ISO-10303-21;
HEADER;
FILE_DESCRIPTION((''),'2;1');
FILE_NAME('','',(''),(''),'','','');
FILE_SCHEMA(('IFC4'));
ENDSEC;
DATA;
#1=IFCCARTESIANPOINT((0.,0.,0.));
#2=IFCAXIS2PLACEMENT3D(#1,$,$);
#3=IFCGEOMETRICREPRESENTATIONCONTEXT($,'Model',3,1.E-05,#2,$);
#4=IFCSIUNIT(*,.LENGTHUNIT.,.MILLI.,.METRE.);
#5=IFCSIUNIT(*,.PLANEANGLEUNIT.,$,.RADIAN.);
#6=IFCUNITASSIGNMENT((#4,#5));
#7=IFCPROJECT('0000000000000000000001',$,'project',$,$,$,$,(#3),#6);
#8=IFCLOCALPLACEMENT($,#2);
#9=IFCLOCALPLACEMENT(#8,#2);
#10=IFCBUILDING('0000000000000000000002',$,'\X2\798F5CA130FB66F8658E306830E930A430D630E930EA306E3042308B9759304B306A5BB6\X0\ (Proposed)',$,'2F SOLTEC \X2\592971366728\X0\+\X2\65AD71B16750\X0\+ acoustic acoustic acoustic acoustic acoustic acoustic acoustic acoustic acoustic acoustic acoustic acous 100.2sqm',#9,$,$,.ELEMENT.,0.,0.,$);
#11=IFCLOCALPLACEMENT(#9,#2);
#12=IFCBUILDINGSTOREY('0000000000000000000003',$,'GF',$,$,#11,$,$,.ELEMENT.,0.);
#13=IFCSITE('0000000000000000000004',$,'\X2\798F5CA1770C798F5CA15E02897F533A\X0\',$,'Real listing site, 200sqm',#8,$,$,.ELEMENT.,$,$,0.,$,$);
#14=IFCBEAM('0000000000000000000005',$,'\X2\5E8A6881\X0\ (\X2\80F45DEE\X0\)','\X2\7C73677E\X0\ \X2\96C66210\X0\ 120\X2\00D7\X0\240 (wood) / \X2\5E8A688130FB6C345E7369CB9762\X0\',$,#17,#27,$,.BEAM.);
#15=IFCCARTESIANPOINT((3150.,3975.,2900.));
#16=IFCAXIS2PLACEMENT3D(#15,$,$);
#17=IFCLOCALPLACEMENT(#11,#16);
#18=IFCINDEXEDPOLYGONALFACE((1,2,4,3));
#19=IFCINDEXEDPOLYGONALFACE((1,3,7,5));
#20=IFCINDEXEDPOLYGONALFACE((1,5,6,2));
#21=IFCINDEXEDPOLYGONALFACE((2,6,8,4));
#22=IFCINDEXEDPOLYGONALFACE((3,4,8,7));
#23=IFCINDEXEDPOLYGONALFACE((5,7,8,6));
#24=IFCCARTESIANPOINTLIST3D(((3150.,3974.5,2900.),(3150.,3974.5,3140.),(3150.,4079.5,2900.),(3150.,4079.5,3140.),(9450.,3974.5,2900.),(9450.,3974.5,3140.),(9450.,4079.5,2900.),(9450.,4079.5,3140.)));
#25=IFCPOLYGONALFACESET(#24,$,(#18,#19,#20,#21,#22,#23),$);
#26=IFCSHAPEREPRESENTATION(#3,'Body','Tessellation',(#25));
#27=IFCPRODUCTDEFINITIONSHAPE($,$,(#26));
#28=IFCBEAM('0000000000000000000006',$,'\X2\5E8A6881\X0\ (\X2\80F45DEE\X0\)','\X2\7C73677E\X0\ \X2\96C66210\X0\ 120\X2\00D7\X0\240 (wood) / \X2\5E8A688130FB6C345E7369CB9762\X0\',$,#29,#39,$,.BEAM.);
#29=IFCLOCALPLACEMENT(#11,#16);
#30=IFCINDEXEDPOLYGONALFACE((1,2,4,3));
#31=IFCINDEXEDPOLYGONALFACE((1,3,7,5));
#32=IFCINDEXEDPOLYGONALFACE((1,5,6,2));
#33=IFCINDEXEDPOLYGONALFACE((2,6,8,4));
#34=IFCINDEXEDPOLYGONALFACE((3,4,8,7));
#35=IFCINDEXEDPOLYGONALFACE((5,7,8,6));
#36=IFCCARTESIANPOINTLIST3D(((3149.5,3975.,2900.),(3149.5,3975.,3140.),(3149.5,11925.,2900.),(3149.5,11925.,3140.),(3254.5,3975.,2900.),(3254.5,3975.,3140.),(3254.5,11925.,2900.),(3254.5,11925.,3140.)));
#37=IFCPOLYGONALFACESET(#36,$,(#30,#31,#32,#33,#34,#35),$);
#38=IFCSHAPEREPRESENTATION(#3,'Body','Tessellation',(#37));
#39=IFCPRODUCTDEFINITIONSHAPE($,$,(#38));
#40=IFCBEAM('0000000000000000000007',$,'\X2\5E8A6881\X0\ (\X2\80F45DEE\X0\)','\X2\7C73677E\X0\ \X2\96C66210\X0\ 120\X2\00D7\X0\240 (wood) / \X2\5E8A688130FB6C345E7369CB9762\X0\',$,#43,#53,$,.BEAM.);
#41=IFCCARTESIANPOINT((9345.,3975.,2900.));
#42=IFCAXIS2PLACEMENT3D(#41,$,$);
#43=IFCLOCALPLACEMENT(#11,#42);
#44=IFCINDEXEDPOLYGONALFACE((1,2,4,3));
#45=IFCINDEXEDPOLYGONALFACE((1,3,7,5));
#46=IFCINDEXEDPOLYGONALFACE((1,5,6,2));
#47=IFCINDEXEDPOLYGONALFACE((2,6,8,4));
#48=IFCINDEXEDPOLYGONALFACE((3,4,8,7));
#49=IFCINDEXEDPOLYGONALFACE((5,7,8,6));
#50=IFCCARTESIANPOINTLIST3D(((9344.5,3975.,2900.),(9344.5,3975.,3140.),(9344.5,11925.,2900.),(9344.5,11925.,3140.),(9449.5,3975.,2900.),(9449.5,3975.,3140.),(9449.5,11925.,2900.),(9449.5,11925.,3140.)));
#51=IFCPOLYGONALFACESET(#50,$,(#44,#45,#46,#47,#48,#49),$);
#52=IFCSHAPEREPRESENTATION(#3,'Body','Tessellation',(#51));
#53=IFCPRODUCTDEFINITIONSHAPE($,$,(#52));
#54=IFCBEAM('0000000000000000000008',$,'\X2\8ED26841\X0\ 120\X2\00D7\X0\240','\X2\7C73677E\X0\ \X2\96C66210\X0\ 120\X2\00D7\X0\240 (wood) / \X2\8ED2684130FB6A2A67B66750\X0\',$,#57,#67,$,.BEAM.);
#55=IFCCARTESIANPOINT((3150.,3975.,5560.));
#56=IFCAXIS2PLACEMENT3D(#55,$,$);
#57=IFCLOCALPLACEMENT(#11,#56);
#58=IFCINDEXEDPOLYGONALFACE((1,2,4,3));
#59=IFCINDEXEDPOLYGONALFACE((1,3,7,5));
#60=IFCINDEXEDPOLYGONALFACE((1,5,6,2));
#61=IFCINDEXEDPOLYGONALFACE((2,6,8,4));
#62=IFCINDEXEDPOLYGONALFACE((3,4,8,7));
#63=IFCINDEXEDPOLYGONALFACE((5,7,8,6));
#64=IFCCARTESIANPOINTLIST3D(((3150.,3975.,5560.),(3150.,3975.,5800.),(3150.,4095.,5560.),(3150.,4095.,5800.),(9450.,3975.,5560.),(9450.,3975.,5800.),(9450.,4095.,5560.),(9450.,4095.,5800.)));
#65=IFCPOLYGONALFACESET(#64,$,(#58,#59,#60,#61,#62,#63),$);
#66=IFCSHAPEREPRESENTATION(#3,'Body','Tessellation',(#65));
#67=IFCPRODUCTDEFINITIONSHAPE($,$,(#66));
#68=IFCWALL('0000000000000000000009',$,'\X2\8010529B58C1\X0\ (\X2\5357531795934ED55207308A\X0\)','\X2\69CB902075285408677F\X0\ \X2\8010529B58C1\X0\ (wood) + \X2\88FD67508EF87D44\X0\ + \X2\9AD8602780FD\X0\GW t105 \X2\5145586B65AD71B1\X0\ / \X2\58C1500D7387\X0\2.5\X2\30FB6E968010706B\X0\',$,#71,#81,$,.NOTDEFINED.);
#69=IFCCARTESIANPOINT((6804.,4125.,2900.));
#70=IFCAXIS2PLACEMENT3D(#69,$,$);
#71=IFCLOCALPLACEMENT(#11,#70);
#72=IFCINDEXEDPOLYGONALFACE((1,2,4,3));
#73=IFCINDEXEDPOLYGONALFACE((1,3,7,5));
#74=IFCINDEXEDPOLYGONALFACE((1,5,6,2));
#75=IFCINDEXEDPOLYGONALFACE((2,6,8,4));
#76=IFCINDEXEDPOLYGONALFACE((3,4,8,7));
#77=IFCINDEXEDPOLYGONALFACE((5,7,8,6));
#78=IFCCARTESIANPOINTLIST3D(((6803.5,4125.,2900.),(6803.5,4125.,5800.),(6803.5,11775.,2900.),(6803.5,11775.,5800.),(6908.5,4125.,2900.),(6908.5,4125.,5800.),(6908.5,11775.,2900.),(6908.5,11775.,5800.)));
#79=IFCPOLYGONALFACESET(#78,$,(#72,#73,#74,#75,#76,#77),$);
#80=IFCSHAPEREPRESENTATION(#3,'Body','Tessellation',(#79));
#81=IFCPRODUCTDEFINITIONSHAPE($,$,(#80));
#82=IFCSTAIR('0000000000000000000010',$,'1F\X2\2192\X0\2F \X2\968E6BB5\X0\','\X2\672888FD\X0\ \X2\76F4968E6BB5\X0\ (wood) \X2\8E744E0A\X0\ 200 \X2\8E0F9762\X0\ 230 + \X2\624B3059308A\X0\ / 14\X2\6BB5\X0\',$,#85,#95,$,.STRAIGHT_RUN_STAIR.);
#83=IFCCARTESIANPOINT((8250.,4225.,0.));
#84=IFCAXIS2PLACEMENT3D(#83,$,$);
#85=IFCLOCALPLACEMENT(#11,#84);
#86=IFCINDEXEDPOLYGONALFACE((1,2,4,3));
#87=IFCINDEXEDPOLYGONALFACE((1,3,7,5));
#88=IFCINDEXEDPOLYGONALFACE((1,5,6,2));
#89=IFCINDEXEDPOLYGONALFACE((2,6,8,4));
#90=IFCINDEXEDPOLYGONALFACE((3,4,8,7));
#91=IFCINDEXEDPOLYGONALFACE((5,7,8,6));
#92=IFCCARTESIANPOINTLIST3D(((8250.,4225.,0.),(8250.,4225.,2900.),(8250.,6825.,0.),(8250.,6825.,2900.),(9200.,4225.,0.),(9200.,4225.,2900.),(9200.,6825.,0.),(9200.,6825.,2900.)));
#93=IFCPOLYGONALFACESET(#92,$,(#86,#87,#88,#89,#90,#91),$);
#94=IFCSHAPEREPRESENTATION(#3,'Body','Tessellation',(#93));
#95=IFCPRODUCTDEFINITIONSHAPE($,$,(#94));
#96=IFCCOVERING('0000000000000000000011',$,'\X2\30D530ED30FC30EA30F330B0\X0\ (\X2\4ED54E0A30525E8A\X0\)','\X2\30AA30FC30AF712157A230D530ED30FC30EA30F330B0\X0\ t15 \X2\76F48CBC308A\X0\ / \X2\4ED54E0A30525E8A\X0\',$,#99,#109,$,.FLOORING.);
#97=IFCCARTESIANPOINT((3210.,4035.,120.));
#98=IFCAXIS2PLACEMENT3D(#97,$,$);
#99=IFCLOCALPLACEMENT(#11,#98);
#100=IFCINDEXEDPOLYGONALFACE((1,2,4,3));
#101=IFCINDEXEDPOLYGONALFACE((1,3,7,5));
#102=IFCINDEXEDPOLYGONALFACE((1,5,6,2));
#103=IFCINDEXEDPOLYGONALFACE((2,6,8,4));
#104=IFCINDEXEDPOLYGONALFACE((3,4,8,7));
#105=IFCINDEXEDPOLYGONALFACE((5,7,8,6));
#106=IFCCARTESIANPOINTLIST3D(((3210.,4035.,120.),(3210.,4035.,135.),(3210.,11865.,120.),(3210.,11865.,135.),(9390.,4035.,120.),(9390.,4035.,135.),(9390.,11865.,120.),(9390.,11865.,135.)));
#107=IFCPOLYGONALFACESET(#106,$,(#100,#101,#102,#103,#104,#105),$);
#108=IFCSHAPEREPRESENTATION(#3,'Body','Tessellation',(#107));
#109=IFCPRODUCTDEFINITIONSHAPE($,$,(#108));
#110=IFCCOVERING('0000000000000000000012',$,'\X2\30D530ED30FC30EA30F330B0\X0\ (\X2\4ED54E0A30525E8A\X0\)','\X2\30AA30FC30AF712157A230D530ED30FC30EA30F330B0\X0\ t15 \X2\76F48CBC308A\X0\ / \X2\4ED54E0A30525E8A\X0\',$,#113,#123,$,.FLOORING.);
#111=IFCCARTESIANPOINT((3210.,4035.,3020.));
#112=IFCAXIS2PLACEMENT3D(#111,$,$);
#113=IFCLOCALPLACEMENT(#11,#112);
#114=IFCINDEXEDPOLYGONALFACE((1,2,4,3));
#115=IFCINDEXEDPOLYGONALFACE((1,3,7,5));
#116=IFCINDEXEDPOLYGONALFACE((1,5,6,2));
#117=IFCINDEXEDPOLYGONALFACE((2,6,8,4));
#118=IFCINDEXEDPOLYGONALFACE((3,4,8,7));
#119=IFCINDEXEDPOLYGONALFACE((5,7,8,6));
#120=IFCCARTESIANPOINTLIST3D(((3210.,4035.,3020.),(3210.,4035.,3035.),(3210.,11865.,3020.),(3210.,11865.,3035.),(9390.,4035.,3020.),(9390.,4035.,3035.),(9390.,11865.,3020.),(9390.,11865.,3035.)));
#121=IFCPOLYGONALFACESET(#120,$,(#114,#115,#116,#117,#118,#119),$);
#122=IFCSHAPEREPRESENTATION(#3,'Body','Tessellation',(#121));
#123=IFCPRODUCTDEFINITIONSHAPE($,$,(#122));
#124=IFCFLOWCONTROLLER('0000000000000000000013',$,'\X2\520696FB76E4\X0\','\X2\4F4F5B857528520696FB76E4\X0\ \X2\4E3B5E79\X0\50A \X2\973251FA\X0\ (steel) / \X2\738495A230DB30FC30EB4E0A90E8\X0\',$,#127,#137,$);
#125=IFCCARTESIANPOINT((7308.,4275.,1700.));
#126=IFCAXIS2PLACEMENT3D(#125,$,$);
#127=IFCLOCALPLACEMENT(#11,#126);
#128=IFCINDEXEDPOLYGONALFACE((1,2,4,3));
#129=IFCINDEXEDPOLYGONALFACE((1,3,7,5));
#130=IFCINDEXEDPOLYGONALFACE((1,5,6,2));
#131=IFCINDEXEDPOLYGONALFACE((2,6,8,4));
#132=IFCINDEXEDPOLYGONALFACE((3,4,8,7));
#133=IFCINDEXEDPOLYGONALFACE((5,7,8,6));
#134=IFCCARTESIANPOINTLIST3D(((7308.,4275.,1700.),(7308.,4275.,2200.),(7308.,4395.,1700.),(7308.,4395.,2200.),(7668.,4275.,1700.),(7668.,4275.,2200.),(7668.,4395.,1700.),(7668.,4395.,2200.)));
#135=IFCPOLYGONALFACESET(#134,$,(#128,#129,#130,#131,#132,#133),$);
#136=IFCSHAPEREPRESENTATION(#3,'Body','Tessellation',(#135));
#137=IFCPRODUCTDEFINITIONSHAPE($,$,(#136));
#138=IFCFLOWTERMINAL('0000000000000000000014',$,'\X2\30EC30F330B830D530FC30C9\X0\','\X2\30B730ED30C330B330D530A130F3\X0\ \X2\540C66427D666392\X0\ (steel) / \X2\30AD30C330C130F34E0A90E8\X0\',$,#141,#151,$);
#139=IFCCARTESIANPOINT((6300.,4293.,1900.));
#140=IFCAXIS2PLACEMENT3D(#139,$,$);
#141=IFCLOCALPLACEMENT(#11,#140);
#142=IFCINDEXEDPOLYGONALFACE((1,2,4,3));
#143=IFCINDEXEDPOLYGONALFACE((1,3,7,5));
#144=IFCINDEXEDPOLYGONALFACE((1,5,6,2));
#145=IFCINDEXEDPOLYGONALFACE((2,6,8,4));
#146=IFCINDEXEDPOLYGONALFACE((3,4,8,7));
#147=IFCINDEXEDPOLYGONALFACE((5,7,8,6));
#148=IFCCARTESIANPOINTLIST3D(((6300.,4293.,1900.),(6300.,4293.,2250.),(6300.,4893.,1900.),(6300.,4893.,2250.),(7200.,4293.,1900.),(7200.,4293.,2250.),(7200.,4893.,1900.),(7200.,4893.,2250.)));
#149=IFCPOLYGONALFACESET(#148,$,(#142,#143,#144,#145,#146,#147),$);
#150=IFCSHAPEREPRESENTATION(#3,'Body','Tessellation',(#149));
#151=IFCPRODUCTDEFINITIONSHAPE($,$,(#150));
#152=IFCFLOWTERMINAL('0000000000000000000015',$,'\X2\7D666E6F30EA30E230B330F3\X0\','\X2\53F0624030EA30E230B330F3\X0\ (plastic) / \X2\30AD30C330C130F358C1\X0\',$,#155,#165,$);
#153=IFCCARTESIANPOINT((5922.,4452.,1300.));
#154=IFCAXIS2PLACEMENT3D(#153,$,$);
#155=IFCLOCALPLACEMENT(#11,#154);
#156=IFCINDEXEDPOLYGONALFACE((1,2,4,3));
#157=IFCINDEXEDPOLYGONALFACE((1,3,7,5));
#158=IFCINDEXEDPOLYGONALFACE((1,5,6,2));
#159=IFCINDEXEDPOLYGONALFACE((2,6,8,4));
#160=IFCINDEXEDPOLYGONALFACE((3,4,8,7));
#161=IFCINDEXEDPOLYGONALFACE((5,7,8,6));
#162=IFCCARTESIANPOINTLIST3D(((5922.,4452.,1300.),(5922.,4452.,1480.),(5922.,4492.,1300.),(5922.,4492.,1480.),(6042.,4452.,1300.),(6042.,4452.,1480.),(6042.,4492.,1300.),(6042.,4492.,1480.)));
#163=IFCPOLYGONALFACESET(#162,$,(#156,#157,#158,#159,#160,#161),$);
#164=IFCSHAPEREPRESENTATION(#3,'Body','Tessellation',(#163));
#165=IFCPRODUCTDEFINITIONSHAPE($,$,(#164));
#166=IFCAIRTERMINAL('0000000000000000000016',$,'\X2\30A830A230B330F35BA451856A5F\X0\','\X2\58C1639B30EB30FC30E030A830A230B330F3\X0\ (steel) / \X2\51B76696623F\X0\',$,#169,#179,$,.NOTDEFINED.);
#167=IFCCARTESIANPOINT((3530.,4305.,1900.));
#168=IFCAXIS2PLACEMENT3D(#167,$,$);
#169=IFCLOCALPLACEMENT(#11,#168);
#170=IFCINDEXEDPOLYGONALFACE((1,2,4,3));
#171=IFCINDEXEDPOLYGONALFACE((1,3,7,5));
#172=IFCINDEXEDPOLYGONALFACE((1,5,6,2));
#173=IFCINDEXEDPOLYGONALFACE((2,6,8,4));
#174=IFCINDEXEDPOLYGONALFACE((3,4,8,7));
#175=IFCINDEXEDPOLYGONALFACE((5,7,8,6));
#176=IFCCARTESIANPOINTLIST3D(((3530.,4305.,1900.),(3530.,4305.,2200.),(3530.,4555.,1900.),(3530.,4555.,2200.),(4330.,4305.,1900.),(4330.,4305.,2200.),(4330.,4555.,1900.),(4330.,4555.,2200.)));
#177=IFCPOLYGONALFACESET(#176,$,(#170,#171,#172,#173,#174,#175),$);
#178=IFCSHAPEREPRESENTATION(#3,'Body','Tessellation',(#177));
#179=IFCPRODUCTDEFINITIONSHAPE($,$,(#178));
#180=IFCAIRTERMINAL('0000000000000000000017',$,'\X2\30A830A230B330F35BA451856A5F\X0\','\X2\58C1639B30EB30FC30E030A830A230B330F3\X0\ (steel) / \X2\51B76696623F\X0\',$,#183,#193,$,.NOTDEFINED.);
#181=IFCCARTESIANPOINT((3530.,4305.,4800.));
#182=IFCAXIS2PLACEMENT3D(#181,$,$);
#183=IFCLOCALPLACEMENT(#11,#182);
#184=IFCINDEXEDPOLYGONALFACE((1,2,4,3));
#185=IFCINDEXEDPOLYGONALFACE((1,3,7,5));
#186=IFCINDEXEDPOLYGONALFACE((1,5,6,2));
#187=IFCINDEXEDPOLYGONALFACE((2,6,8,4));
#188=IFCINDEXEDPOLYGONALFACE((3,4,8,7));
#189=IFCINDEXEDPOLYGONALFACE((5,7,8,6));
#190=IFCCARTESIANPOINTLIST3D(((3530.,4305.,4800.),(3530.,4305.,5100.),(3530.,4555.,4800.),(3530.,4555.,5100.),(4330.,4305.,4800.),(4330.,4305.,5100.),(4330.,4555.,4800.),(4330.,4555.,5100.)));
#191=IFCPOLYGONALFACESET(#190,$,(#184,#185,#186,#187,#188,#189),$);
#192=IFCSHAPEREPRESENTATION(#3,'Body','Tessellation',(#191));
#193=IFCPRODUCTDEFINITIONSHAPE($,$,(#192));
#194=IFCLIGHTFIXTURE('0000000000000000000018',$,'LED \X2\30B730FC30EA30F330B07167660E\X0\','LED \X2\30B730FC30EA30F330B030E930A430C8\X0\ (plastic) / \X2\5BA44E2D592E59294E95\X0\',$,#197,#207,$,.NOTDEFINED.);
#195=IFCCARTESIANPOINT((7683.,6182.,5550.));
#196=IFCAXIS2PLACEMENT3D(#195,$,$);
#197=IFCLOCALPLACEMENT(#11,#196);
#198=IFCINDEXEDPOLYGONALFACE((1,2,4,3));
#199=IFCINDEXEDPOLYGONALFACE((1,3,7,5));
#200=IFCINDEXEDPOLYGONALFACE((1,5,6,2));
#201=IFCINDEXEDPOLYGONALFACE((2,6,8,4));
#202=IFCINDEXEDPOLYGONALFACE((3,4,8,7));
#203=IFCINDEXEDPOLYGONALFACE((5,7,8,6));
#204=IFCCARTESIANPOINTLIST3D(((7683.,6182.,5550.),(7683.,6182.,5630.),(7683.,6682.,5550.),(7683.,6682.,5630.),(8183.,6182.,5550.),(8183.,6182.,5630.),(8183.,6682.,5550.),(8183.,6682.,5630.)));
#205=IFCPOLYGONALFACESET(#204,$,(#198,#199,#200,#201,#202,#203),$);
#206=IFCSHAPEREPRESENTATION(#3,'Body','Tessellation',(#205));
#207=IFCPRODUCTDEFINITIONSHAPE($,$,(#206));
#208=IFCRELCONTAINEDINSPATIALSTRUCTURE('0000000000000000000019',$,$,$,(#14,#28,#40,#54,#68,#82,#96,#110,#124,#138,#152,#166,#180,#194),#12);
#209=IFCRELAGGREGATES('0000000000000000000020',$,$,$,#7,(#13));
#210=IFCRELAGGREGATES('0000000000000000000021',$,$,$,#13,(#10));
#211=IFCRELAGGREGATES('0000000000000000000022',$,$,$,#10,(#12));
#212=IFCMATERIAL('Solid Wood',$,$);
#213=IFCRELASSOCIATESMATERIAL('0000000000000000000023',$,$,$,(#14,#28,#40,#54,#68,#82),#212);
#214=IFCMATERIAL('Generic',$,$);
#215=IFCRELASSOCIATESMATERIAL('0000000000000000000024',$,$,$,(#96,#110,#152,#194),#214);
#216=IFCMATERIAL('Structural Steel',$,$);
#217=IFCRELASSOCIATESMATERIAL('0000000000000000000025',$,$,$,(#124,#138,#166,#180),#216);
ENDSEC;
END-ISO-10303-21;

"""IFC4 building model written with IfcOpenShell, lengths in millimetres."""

from ifc_helpers import new_model, si_unit, frame, frame_2d, origin, place, context, project, spatial, rectangle, extrude, material, element, save


model = new_model("IFC4")

# Units and contexts
model_context = context("Model", 3, precision=1e-05, world=origin())
ifc_project = project(units=[si_unit("LENGTHUNIT", "METRE", prefix="MILLI"), si_unit("PLANEANGLEUNIT", "RADIAN")], contexts=[model_context])

# Site, building, storey
site_placement = place(None, origin())
site = spatial("IfcSite", under=ifc_project, at=site_placement, Name="福岡県福岡市西区", ObjectType="Real listing site, 200sqm", CompositionType="ELEMENT", RefElevation=0.0)
building_placement = place(site_placement, origin())
building = spatial("IfcBuilding", under=site, at=building_placement, Name="福岡・書斎とライブラリのある静かな家 (Proposed)", ObjectType="2F SOLTEC 天然木+断熱材+ acoustic acoustic acoustic acoustic acoustic acoustic acoustic acoustic acoustic acoustic acoustic acous 100.2sqm", CompositionType="ELEMENT", ElevationOfRefHeight=0.0, ElevationOfTerrain=0.0)
storey_placement = place(building_placement, origin())
storey = spatial("IfcBuildingStorey", under=building, at=storey_placement, Name="GF", CompositionType="ELEMENT", Elevation=0.0)

# Shared definitions
ifc_material_1 = material(Name="Solid Wood")

# Beams
beam_1_placement = place(storey_placement, frame((3150.0, 3975.0, 2900.0)))
element("IfcBeam", 1, at=beam_1_placement, inside=storey, material=ifc_material_1, Name="床梁 (胴差)", Description="米松 集成 120×240 (wood) / 床梁・水平構面", PredefinedType="BEAM", context=model_context, shape_type="SweptSolid", body=[
    extrude(rectangle(XDim=6300.0, YDim=105.0, at=frame_2d((3150.0, 52.0))), frame((3150.0, 3975.0, 2900.0)), (0.0, 0.0, 1.0), 240.0),
])
beam_2_placement = place(storey_placement, frame((3150.0, 3975.0, 2900.0)))
element("IfcBeam", 2, at=beam_2_placement, inside=storey, material=ifc_material_1, Name="床梁 (胴差)", Description="米松 集成 120×240 (wood) / 床梁・水平構面", PredefinedType="BEAM", context=model_context, shape_type="SweptSolid", body=[
    extrude(rectangle(XDim=105.0, YDim=7950.0, at=frame_2d((52.0, 3975.0))), frame((3150.0, 3975.0, 2900.0)), (0.0, 0.0, 1.0), 240.0),
])
beam_3_placement = place(storey_placement, frame((9345.0, 3975.0, 2900.0)))
element("IfcBeam", 3, at=beam_3_placement, inside=storey, material=ifc_material_1, Name="床梁 (胴差)", Description="米松 集成 120×240 (wood) / 床梁・水平構面", PredefinedType="BEAM", context=model_context, shape_type="SweptSolid", body=[
    extrude(rectangle(XDim=105.0, YDim=7950.0, at=frame_2d((52.0, 3975.0))), frame((9345.0, 3975.0, 2900.0)), (0.0, 0.0, 1.0), 240.0),
])
beam_4_placement = place(storey_placement, frame((3150.0, 3975.0, 5560.0)))
element("IfcBeam", 4, at=beam_4_placement, inside=storey, material=ifc_material_1, Name="軒桁 120×240", Description="米松 集成 120×240 (wood) / 軒桁・横架材", PredefinedType="BEAM", context=model_context, shape_type="SweptSolid", body=[
    extrude(rectangle(XDim=6300.0, YDim=120.0, at=frame_2d((3150.0, 60.0))), frame((3150.0, 3975.0, 5560.0)), (0.0, 0.0, 1.0), 240.0),
])

# Wall
wall_1_placement = place(storey_placement, frame((6804.0, 4125.0, 2900.0)))
element("IfcWall", 5, at=wall_1_placement, inside=storey, material=ifc_material_1, Name="耐力壁 (南北間仕切り)", Description="構造用合板 耐力壁 (wood) + 製材軸組 + 高性能GW t105 充填断熱 / 壁倍率2.5・準耐火", PredefinedType="NOTDEFINED", context=model_context, shape_type="SweptSolid", body=[
    extrude(rectangle(XDim=105.0, YDim=7650.0, at=frame_2d((52.0, 3825.0))), frame((6804.0, 4125.0, 2900.0)), (0.0, 0.0, 1.0), 2900.0),
])

# Stair
stair_placement = place(storey_placement, frame((8250.0, 4225.0, 0.0)))
element("IfcStair", 6, at=stair_placement, inside=storey, material=ifc_material_1, Name="1F→2F 階段", Description="木製 直階段 (wood) 蹴上 200 踏面 230 + 手すり / 14段", PredefinedType="STRAIGHT_RUN_STAIR", context=model_context, shape_type="SweptSolid", body=[
    extrude(rectangle(XDim=950.0, YDim=2600.0, at=frame_2d((475.0, 1300.0))), frame((8250.0, 4225.0, 0.0)), (0.0, 0.0, 1.0), 2900.0),
])

# Coverings
ifc_material_2 = material(Name="Generic")
covering_1_placement = place(storey_placement, frame((3210.0, 4035.0, 120.0)))
element("IfcCovering", 7, at=covering_1_placement, inside=storey, material=ifc_material_2, Name="フローリング (仕上げ床)", Description="オーク無垢フローリング t15 直貼り / 仕上げ床", PredefinedType="FLOORING", context=model_context, shape_type="SweptSolid", body=[
    extrude(rectangle(XDim=6180.0, YDim=7830.0, at=frame_2d((3090.0, 3915.0))), frame((3210.0, 4035.0, 120.0)), (0.0, 0.0, 1.0), 15.0),
])
covering_2_placement = place(storey_placement, frame((3210.0, 4035.0, 3020.0)))
element("IfcCovering", 8, at=covering_2_placement, inside=storey, material=ifc_material_2, Name="フローリング (仕上げ床)", Description="オーク無垢フローリング t15 直貼り / 仕上げ床", PredefinedType="FLOORING", context=model_context, shape_type="SweptSolid", body=[
    extrude(rectangle(XDim=6180.0, YDim=7830.0, at=frame_2d((3090.0, 3915.0))), frame((3210.0, 4035.0, 3020.0)), (0.0, 0.0, 1.0), 15.0),
])

# Flow controller
ifc_material_3 = material(Name="Structural Steel")
flow_controller_placement = place(storey_placement, frame((7308.0, 4275.0, 1700.0)))
element("IfcFlowController", 9, at=flow_controller_placement, inside=storey, material=ifc_material_3, Name="分電盤", Description="住宅用分電盤 主幹50A 露出 (steel) / 玄関ホール上部", context=model_context, shape_type="SweptSolid", body=[
    extrude(rectangle(XDim=360.0, YDim=120.0, at=frame_2d((180.0, 60.0))), frame((7308.0, 4275.0, 1700.0)), (0.0, 0.0, 1.0), 500.0),
])

# Flow terminals
flow_terminal_1_placement = place(storey_placement, frame((6300.0, 4293.0, 1900.0)))
element("IfcFlowTerminal", 10, at=flow_terminal_1_placement, inside=storey, material=ifc_material_3, Name="レンジフード", Description="シロッコファン 同時給排 (steel) / キッチン上部", context=model_context, shape_type="SweptSolid", body=[
    extrude(rectangle(XDim=900.0, YDim=600.0, at=frame_2d((450.0, 300.0))), frame((6300.0, 4293.0, 1900.0)), (0.0, 0.0, 1.0), 350.0),
])
flow_terminal_2_placement = place(storey_placement, frame((5922.0, 4452.0, 1300.0)))
element("IfcFlowTerminal", 11, at=flow_terminal_2_placement, inside=storey, material=ifc_material_2, Name="給湯リモコン", Description="台所リモコン (plastic) / キッチン壁", context=model_context, shape_type="SweptSolid", body=[
    extrude(rectangle(XDim=120.0, YDim=40.0, at=frame_2d((60.0, 20.0))), frame((5922.0, 4452.0, 1300.0)), (0.0, 0.0, 1.0), 180.0),
])

# Air terminals
air_terminal_1_placement = place(storey_placement, frame((3530.0, 4305.0, 1900.0)))
element("IfcAirTerminal", 12, at=air_terminal_1_placement, inside=storey, material=ifc_material_3, Name="エアコン室内機", Description="壁掛ルームエアコン (steel) / 冷暖房", PredefinedType="NOTDEFINED", context=model_context, shape_type="SweptSolid", body=[
    extrude(rectangle(XDim=800.0, YDim=250.0, at=frame_2d((400.0, 125.0))), frame((3530.0, 4305.0, 1900.0)), (0.0, 0.0, 1.0), 300.0),
])
air_terminal_2_placement = place(storey_placement, frame((3530.0, 4305.0, 4800.0)))
element("IfcAirTerminal", 13, at=air_terminal_2_placement, inside=storey, material=ifc_material_3, Name="エアコン室内機", Description="壁掛ルームエアコン (steel) / 冷暖房", PredefinedType="NOTDEFINED", context=model_context, shape_type="SweptSolid", body=[
    extrude(rectangle(XDim=800.0, YDim=250.0, at=frame_2d((400.0, 125.0))), frame((3530.0, 4305.0, 4800.0)), (0.0, 0.0, 1.0), 300.0),
])

# Light fixture
light_fixture_placement = place(storey_placement, frame((7683.0, 6182.0, 5550.0)))
element("IfcLightFixture", 14, at=light_fixture_placement, inside=storey, material=ifc_material_2, Name="LED シーリング照明", Description="LED シーリングライト (plastic) / 室中央天井", PredefinedType="NOTDEFINED", context=model_context, shape_type="SweptSolid", body=[
    extrude(rectangle(XDim=500.0, YDim=500.0, at=frame_2d((250.0, 250.0))), frame((7683.0, 6182.0, 5550.0)), (0.0, 0.0, 1.0), 80.0),
])

save(model, "model.ifc")
